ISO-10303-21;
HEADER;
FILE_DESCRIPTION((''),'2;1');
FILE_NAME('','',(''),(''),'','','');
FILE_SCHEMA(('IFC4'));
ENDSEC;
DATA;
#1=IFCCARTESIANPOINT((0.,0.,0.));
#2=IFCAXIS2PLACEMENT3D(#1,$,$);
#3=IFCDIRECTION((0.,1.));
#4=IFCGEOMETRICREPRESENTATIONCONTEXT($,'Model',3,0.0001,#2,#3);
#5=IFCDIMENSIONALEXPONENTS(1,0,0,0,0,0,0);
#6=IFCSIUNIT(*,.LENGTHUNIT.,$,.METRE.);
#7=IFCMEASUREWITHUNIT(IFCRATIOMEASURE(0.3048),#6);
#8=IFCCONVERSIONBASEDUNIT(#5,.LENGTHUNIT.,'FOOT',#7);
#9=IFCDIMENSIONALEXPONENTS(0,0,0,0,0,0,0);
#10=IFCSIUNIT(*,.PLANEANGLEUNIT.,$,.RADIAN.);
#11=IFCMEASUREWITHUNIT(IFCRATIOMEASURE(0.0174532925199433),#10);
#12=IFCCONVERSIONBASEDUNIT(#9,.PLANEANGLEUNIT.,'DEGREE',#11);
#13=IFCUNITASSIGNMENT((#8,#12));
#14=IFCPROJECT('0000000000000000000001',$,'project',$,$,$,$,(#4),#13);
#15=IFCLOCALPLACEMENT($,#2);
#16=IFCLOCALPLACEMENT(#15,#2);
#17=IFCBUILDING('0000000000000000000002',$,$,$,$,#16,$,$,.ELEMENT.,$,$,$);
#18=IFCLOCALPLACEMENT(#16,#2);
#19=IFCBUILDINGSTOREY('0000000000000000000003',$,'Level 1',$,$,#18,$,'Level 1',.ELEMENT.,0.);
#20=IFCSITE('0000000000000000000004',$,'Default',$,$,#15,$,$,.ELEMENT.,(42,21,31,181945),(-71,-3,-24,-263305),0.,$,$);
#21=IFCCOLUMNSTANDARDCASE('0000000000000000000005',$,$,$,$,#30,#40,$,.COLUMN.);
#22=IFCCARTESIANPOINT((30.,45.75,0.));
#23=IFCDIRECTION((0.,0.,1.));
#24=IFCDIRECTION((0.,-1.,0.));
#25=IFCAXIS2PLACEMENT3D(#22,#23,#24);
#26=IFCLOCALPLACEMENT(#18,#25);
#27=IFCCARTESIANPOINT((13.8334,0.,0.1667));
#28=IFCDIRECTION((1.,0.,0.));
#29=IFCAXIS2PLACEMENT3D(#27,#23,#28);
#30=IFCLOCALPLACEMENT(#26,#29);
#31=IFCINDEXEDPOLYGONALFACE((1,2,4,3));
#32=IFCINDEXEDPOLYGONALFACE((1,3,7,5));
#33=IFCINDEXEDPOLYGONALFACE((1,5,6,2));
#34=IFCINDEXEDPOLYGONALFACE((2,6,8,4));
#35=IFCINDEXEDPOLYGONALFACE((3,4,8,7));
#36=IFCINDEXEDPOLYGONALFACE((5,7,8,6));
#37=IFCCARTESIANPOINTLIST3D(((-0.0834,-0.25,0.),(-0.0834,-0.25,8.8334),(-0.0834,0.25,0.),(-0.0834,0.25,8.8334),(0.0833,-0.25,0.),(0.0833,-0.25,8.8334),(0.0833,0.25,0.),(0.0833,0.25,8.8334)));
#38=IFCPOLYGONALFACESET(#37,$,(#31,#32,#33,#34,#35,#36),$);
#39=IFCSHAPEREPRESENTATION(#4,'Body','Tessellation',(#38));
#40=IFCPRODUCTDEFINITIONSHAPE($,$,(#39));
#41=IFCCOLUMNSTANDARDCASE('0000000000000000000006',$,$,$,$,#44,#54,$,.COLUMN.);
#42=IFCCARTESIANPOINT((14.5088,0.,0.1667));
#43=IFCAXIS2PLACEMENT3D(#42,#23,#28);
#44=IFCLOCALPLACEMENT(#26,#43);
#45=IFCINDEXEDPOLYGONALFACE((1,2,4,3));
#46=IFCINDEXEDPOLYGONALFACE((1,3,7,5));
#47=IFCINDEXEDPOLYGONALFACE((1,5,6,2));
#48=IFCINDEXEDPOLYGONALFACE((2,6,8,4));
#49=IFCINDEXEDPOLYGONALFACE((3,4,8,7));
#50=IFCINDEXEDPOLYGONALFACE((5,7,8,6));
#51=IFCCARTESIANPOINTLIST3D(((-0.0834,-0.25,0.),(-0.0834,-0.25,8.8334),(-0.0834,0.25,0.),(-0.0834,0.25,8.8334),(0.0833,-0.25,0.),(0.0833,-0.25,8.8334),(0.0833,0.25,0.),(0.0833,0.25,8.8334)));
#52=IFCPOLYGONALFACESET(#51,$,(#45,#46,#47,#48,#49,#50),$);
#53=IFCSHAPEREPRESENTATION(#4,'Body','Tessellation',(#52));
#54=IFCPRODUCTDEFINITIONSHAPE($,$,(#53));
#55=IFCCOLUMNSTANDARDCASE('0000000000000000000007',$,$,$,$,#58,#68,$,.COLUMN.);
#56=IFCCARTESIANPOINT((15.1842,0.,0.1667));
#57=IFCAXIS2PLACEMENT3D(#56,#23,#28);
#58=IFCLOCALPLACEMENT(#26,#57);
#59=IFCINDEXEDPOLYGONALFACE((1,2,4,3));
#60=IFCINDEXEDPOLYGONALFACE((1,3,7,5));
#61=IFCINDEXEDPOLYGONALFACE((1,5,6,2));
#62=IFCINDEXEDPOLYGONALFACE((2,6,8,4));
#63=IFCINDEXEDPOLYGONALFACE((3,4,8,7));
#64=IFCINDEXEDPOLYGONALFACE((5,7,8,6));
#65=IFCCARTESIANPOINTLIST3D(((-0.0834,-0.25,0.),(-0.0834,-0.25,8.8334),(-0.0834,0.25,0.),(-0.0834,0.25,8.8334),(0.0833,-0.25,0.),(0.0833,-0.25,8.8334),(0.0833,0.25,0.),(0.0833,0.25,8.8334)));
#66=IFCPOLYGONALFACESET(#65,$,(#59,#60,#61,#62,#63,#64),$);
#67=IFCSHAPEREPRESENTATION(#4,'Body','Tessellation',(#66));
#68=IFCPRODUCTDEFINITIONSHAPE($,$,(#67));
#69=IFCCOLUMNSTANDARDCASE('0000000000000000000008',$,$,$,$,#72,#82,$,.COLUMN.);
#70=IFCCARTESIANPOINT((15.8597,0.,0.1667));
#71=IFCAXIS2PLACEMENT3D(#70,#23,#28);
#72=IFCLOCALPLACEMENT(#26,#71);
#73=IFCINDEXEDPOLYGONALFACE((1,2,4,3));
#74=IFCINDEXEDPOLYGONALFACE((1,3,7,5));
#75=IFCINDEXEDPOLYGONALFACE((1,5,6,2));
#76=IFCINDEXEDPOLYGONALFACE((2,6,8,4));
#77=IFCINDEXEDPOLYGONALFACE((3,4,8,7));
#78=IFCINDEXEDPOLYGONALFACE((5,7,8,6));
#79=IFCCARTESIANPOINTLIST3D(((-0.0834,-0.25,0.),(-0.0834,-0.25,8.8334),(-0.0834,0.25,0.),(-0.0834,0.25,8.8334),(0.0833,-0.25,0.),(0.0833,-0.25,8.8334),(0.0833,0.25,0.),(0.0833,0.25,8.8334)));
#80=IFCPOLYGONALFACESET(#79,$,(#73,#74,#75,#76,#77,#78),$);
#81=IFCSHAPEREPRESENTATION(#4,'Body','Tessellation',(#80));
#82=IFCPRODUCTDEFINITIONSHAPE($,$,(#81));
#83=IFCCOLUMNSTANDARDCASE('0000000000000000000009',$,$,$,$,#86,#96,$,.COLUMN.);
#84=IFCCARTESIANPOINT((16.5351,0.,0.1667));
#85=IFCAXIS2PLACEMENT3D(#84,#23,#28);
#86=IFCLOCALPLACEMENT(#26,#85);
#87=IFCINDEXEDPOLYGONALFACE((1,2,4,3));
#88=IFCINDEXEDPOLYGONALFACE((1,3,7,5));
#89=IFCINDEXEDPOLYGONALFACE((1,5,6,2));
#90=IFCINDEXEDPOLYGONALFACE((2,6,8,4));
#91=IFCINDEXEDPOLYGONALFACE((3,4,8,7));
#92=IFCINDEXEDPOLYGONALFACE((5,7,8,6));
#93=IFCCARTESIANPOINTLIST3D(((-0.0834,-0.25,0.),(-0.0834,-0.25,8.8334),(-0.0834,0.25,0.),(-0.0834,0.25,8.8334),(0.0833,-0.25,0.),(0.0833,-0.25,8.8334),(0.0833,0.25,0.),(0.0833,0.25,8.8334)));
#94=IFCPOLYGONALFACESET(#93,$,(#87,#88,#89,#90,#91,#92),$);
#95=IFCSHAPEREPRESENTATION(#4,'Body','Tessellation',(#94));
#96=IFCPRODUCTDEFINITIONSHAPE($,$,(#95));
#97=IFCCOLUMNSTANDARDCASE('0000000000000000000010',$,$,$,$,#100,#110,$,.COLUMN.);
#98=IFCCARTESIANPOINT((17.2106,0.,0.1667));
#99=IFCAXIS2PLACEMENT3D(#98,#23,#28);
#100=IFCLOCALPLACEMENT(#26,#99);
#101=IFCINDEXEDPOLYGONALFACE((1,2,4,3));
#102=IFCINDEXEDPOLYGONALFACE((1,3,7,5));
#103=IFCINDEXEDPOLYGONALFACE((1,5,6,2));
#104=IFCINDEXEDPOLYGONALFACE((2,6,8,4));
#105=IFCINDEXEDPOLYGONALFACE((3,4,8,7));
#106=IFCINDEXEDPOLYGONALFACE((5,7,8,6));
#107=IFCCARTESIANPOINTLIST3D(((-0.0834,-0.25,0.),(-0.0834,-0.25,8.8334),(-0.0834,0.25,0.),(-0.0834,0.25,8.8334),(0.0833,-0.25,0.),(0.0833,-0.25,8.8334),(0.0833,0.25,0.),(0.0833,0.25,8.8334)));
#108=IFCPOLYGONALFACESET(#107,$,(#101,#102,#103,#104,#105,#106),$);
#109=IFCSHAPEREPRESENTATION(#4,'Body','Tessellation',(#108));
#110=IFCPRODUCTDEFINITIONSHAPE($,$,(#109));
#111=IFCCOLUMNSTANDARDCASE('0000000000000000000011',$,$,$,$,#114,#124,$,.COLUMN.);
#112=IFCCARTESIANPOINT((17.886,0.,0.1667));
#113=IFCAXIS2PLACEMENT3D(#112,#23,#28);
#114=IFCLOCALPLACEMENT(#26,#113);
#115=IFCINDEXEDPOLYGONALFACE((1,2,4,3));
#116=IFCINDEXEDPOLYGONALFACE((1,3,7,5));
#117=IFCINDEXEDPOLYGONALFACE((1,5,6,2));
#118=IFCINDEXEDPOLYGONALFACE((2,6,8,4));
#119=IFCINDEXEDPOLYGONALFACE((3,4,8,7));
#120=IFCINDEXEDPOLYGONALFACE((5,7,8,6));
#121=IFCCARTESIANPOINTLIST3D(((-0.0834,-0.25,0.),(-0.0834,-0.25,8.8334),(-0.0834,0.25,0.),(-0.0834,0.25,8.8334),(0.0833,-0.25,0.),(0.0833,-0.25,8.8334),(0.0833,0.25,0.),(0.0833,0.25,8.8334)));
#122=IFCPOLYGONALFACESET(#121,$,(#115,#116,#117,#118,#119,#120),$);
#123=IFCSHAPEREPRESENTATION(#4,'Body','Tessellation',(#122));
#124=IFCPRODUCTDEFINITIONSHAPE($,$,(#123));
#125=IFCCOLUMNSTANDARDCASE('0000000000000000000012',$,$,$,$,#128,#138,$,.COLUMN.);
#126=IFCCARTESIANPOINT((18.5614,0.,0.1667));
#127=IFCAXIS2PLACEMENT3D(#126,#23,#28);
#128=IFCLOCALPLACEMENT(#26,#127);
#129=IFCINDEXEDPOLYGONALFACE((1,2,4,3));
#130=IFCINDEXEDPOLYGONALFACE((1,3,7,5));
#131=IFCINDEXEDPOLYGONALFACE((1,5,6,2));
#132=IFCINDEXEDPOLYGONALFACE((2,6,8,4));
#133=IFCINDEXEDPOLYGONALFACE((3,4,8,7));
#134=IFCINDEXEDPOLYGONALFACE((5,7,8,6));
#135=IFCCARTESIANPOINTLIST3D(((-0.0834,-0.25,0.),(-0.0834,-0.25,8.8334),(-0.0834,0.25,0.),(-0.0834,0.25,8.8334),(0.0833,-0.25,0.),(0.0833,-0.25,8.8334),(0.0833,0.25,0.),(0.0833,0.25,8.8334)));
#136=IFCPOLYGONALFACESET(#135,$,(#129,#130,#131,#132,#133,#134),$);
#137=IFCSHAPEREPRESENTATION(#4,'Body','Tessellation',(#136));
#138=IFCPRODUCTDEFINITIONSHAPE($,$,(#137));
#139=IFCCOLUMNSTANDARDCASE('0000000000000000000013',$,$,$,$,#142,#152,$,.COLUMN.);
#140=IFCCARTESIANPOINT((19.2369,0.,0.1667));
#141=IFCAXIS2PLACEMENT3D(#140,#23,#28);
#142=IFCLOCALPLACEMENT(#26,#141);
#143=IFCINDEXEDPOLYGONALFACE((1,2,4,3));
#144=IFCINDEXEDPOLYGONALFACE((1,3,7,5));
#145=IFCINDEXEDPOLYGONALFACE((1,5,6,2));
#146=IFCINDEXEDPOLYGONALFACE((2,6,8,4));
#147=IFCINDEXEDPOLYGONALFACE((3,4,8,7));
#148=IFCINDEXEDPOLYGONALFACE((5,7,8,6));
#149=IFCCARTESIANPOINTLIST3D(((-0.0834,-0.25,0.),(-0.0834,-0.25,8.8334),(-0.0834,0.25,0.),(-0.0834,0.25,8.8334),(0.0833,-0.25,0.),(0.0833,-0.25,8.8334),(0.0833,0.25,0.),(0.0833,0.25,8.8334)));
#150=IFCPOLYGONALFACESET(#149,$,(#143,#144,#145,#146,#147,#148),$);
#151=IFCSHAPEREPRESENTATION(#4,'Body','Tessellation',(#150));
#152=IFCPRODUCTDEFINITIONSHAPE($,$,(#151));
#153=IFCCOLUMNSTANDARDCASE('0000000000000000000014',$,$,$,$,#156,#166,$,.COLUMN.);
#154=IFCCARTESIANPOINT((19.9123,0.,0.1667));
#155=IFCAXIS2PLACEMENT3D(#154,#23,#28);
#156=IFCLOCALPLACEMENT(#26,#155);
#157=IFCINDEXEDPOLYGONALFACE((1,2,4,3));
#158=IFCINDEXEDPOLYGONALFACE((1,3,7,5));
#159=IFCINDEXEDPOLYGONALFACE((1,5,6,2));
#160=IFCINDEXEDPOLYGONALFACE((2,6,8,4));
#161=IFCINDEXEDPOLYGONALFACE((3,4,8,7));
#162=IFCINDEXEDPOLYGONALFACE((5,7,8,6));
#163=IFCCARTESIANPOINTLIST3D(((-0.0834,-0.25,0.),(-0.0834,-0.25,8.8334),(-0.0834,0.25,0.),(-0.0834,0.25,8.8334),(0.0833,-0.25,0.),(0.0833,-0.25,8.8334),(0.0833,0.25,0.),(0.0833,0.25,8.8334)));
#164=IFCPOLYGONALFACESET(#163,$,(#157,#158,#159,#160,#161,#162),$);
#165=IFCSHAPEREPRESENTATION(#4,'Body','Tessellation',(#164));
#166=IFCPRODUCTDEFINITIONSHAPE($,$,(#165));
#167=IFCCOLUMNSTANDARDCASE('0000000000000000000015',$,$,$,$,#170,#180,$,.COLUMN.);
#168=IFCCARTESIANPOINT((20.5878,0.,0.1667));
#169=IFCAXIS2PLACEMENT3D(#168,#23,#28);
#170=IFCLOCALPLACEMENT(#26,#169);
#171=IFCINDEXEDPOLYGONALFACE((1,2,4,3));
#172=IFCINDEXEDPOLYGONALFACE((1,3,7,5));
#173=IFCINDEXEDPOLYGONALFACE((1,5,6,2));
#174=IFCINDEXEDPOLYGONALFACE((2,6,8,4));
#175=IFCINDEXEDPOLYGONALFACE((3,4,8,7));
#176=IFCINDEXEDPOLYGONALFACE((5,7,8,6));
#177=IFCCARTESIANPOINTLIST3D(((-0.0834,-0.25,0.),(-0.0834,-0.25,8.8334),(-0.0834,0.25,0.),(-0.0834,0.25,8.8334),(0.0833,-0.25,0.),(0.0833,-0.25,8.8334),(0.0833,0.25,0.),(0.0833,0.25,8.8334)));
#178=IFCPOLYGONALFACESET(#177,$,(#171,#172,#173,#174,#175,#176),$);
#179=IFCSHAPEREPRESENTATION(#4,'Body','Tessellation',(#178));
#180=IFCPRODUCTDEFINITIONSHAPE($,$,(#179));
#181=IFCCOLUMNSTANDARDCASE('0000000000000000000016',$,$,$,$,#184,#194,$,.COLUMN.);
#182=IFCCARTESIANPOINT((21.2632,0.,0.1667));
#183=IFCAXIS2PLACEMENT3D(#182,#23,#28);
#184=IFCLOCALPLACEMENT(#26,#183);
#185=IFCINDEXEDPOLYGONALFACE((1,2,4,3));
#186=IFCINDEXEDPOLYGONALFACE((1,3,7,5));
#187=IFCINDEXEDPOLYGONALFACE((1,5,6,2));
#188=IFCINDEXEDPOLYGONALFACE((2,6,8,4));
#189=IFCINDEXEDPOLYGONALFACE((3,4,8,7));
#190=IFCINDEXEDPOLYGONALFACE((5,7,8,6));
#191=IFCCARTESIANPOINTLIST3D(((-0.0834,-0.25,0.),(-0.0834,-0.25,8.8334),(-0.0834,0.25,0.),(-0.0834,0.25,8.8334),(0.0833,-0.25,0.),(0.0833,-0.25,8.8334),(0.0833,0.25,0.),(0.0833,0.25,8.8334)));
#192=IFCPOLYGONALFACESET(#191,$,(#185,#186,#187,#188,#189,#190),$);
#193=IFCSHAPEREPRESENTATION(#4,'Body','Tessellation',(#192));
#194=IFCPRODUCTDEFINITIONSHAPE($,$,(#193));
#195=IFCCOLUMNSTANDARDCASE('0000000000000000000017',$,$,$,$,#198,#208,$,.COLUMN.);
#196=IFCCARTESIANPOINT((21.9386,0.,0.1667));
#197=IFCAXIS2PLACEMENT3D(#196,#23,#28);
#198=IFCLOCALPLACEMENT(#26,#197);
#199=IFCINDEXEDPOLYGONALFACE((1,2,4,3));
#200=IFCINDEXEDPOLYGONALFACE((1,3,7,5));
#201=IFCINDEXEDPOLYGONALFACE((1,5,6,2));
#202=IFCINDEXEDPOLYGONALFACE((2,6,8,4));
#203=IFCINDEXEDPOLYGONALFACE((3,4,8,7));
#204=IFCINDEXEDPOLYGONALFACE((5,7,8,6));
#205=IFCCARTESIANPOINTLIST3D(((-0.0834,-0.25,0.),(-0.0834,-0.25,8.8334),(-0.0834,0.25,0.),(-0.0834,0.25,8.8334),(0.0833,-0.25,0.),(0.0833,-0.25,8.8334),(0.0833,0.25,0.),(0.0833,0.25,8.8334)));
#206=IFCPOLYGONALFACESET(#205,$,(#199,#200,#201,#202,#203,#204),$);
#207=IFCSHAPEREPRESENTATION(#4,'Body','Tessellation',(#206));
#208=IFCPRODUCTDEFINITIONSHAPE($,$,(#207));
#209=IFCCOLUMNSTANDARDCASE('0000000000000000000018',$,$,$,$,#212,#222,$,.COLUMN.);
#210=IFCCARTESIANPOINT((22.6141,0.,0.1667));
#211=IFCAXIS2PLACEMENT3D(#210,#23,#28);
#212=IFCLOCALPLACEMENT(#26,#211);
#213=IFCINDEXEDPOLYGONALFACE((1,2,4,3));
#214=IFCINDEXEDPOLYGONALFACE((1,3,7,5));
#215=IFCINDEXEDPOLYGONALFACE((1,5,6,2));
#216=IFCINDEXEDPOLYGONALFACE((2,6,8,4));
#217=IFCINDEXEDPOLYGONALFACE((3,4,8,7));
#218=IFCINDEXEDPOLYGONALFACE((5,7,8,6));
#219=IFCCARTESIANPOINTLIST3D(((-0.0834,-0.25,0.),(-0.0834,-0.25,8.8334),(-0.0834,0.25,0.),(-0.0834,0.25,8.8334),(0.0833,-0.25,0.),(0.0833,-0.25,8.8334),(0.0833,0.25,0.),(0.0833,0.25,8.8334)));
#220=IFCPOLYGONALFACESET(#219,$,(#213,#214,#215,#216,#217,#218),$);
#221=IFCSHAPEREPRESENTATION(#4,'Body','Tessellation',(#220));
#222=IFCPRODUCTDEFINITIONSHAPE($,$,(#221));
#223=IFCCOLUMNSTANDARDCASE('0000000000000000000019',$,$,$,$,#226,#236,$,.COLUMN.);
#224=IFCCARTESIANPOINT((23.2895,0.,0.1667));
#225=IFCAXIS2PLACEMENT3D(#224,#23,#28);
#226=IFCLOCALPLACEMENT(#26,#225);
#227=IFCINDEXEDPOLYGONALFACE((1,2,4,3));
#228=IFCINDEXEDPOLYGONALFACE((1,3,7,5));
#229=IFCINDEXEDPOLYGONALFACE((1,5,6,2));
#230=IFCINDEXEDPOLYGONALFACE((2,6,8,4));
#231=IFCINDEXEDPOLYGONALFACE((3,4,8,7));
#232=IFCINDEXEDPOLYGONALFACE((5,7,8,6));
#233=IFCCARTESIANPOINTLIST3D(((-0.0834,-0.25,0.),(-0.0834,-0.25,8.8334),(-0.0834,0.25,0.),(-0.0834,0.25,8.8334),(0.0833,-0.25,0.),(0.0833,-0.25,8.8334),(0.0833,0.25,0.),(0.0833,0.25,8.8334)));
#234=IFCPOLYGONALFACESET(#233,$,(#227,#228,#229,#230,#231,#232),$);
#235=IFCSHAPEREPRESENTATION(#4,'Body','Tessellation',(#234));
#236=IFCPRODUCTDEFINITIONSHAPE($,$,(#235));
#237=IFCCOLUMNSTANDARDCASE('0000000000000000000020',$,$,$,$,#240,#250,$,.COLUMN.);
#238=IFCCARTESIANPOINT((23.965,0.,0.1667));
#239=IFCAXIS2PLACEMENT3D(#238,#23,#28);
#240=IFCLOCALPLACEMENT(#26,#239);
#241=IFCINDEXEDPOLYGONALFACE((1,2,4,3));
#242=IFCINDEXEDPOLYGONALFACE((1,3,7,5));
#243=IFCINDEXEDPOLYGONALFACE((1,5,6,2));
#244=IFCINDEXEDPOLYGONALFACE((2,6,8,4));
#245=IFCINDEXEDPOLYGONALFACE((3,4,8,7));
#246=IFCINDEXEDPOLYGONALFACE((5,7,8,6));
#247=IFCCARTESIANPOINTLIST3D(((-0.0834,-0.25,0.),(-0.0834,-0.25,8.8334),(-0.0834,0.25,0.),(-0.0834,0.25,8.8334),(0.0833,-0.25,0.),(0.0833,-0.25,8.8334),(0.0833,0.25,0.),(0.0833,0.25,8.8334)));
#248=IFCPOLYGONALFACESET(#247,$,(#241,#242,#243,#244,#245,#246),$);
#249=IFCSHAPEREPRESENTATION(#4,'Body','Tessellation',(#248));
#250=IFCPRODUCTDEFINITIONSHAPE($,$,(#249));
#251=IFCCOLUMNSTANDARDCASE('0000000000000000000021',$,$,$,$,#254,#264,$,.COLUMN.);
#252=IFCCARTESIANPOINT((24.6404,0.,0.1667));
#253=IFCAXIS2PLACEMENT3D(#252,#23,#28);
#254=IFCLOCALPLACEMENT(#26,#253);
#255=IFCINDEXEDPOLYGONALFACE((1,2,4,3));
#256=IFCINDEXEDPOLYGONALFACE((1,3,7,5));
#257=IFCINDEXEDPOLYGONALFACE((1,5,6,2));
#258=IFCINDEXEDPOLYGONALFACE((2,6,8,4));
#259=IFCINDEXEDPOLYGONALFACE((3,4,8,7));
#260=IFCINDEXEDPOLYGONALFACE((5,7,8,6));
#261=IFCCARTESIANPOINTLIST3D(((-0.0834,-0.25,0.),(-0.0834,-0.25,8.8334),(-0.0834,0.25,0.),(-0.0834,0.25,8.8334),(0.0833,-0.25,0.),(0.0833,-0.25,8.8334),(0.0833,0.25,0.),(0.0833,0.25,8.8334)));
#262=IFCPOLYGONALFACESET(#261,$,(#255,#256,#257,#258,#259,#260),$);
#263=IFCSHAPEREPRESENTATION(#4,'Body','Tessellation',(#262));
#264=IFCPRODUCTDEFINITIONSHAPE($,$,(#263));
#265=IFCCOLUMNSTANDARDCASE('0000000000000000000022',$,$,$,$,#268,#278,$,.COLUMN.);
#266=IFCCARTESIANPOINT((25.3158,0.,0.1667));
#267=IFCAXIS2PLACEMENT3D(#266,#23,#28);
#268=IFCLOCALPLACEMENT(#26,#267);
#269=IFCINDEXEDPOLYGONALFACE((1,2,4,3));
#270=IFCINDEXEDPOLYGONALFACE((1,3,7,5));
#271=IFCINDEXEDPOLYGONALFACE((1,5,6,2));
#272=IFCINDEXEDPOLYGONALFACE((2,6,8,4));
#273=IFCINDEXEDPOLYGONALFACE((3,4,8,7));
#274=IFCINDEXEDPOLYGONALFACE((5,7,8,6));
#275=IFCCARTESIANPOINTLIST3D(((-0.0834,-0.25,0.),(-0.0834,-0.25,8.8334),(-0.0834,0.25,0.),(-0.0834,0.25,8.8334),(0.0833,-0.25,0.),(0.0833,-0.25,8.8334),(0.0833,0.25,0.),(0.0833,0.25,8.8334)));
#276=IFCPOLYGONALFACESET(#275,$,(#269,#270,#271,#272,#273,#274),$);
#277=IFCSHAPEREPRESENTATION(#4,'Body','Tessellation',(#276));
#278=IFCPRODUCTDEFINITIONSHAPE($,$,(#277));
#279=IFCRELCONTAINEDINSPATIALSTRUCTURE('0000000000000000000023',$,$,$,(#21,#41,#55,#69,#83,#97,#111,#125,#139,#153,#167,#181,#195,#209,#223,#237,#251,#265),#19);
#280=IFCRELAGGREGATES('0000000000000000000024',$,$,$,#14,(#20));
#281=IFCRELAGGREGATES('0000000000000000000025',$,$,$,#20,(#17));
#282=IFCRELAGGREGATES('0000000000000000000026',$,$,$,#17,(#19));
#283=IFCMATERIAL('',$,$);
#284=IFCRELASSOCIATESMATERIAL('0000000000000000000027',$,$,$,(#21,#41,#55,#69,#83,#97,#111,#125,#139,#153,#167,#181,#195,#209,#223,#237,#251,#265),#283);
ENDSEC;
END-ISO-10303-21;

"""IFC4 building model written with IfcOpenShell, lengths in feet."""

from ifc_helpers import new_model, entity, si_unit, converted_unit, direction, frame, origin, place, context, project, spatial, rectangle, extrude, material, element, save


model = new_model("IFC4")

# Units and contexts
model_context = context("Model", 3, precision=0.0001, world=origin(), true_north=direction((0.0, 1.0)))
ifc_project = project(units=[converted_unit("LENGTHUNIT", "FOOT", entity("IfcRatioMeasure", 0.3048), si_unit("LENGTHUNIT", "METRE"), dimensions=[1, 0, 0, 0, 0, 0, 0]), converted_unit("PLANEANGLEUNIT", "DEGREE", entity("IfcRatioMeasure", 0.0174532925199433), si_unit("PLANEANGLEUNIT", "RADIAN"), dimensions=[0, 0, 0, 0, 0, 0, 0])], contexts=[model_context])

# Site, building, storey
site_placement = place(None, origin())
site = spatial("IfcSite", under=ifc_project, at=site_placement, Name="Default", CompositionType="ELEMENT", RefLatitude=(42, 21, 31, 181945), RefLongitude=(-71, -3, -24, -263305), RefElevation=0.0)
building_placement = place(site_placement, origin())
building = spatial("IfcBuilding", under=site, at=building_placement, CompositionType="ELEMENT")
storey_placement = place(building_placement, origin())
storey = spatial("IfcBuildingStorey", under=building, at=storey_placement, Name="Level 1", LongName="Level 1", CompositionType="ELEMENT", Elevation=0.0)

# Columns
ifc_material_1 = material(Name="")
placement_1 = place(storey_placement, frame((30.0, 45.75, 0.0), z_axis=(0.0, 0.0, 1.0), x_axis=(0.0, -1.0, 0.0)))
for number, where, z_axis, x_axis in (
    (1, (13.8334, 0.0, 0.1667), (0.0, 0.0, 1.0), (1.0, 0.0, 0.0)),
    (2, (14.5088, 0.0, 0.1667), (0.0, 0.0, 1.0), (1.0, 0.0, 0.0)),
    (3, (15.1842, 0.0, 0.1667), (0.0, 0.0, 1.0), (1.0, 0.0, 0.0)),
    (4, (15.8597, 0.0, 0.1667), (0.0, 0.0, 1.0), (1.0, 0.0, 0.0)),
    (5, (16.5351, 0.0, 0.1667), (0.0, 0.0, 1.0), (1.0, 0.0, 0.0)),
    (6, (17.2106, 0.0, 0.1667), (0.0, 0.0, 1.0), (1.0, 0.0, 0.0)),
    (7, (17.886, 0.0, 0.1667), (0.0, 0.0, 1.0), (1.0, 0.0, 0.0)),
    (8, (18.5614, 0.0, 0.1667), (0.0, 0.0, 1.0), (1.0, 0.0, 0.0)),
    (9, (19.2369, 0.0, 0.1667), (0.0, 0.0, 1.0), (1.0, 0.0, 0.0)),
    (10, (19.9123, 0.0, 0.1667), (0.0, 0.0, 1.0), (1.0, 0.0, 0.0)),
    (11, (20.5878, 0.0, 0.1667), (0.0, 0.0, 1.0), (1.0, 0.0, 0.0)),
    (12, (21.2632, 0.0, 0.1667), (0.0, 0.0, 1.0), (1.0, 0.0, 0.0)),
    (13, (21.9386, 0.0, 0.1667), (0.0, 0.0, 1.0), (1.0, 0.0, 0.0)),
    (14, (22.6141, 0.0, 0.1667), (0.0, 0.0, 1.0), (1.0, 0.0, 0.0)),
    (15, (23.2895, 0.0, 0.1667), (0.0, 0.0, 1.0), (1.0, 0.0, 0.0)),
    (16, (23.965, 0.0, 0.1667), (0.0, 0.0, 1.0), (1.0, 0.0, 0.0)),
    (17, (24.6404, 0.0, 0.1667), (0.0, 0.0, 1.0), (1.0, 0.0, 0.0)),
    (18, (25.3158, 0.0, 0.1667), (0.0, 0.0, 1.0), (1.0, 0.0, 0.0)),
):
    element("IfcColumnStandardCase", number, at=place(placement_1, frame(where, z_axis=z_axis, x_axis=x_axis)), inside=storey, material=ifc_material_1, PredefinedType="COLUMN", context=model_context, shape_type="SweptSolid", body=[
        extrude(rectangle(XDim=0.1667, YDim=0.5), origin(), (0.0, 0.0, 1.0), 8.8334),
    ])

save(model, "model.ifc")
